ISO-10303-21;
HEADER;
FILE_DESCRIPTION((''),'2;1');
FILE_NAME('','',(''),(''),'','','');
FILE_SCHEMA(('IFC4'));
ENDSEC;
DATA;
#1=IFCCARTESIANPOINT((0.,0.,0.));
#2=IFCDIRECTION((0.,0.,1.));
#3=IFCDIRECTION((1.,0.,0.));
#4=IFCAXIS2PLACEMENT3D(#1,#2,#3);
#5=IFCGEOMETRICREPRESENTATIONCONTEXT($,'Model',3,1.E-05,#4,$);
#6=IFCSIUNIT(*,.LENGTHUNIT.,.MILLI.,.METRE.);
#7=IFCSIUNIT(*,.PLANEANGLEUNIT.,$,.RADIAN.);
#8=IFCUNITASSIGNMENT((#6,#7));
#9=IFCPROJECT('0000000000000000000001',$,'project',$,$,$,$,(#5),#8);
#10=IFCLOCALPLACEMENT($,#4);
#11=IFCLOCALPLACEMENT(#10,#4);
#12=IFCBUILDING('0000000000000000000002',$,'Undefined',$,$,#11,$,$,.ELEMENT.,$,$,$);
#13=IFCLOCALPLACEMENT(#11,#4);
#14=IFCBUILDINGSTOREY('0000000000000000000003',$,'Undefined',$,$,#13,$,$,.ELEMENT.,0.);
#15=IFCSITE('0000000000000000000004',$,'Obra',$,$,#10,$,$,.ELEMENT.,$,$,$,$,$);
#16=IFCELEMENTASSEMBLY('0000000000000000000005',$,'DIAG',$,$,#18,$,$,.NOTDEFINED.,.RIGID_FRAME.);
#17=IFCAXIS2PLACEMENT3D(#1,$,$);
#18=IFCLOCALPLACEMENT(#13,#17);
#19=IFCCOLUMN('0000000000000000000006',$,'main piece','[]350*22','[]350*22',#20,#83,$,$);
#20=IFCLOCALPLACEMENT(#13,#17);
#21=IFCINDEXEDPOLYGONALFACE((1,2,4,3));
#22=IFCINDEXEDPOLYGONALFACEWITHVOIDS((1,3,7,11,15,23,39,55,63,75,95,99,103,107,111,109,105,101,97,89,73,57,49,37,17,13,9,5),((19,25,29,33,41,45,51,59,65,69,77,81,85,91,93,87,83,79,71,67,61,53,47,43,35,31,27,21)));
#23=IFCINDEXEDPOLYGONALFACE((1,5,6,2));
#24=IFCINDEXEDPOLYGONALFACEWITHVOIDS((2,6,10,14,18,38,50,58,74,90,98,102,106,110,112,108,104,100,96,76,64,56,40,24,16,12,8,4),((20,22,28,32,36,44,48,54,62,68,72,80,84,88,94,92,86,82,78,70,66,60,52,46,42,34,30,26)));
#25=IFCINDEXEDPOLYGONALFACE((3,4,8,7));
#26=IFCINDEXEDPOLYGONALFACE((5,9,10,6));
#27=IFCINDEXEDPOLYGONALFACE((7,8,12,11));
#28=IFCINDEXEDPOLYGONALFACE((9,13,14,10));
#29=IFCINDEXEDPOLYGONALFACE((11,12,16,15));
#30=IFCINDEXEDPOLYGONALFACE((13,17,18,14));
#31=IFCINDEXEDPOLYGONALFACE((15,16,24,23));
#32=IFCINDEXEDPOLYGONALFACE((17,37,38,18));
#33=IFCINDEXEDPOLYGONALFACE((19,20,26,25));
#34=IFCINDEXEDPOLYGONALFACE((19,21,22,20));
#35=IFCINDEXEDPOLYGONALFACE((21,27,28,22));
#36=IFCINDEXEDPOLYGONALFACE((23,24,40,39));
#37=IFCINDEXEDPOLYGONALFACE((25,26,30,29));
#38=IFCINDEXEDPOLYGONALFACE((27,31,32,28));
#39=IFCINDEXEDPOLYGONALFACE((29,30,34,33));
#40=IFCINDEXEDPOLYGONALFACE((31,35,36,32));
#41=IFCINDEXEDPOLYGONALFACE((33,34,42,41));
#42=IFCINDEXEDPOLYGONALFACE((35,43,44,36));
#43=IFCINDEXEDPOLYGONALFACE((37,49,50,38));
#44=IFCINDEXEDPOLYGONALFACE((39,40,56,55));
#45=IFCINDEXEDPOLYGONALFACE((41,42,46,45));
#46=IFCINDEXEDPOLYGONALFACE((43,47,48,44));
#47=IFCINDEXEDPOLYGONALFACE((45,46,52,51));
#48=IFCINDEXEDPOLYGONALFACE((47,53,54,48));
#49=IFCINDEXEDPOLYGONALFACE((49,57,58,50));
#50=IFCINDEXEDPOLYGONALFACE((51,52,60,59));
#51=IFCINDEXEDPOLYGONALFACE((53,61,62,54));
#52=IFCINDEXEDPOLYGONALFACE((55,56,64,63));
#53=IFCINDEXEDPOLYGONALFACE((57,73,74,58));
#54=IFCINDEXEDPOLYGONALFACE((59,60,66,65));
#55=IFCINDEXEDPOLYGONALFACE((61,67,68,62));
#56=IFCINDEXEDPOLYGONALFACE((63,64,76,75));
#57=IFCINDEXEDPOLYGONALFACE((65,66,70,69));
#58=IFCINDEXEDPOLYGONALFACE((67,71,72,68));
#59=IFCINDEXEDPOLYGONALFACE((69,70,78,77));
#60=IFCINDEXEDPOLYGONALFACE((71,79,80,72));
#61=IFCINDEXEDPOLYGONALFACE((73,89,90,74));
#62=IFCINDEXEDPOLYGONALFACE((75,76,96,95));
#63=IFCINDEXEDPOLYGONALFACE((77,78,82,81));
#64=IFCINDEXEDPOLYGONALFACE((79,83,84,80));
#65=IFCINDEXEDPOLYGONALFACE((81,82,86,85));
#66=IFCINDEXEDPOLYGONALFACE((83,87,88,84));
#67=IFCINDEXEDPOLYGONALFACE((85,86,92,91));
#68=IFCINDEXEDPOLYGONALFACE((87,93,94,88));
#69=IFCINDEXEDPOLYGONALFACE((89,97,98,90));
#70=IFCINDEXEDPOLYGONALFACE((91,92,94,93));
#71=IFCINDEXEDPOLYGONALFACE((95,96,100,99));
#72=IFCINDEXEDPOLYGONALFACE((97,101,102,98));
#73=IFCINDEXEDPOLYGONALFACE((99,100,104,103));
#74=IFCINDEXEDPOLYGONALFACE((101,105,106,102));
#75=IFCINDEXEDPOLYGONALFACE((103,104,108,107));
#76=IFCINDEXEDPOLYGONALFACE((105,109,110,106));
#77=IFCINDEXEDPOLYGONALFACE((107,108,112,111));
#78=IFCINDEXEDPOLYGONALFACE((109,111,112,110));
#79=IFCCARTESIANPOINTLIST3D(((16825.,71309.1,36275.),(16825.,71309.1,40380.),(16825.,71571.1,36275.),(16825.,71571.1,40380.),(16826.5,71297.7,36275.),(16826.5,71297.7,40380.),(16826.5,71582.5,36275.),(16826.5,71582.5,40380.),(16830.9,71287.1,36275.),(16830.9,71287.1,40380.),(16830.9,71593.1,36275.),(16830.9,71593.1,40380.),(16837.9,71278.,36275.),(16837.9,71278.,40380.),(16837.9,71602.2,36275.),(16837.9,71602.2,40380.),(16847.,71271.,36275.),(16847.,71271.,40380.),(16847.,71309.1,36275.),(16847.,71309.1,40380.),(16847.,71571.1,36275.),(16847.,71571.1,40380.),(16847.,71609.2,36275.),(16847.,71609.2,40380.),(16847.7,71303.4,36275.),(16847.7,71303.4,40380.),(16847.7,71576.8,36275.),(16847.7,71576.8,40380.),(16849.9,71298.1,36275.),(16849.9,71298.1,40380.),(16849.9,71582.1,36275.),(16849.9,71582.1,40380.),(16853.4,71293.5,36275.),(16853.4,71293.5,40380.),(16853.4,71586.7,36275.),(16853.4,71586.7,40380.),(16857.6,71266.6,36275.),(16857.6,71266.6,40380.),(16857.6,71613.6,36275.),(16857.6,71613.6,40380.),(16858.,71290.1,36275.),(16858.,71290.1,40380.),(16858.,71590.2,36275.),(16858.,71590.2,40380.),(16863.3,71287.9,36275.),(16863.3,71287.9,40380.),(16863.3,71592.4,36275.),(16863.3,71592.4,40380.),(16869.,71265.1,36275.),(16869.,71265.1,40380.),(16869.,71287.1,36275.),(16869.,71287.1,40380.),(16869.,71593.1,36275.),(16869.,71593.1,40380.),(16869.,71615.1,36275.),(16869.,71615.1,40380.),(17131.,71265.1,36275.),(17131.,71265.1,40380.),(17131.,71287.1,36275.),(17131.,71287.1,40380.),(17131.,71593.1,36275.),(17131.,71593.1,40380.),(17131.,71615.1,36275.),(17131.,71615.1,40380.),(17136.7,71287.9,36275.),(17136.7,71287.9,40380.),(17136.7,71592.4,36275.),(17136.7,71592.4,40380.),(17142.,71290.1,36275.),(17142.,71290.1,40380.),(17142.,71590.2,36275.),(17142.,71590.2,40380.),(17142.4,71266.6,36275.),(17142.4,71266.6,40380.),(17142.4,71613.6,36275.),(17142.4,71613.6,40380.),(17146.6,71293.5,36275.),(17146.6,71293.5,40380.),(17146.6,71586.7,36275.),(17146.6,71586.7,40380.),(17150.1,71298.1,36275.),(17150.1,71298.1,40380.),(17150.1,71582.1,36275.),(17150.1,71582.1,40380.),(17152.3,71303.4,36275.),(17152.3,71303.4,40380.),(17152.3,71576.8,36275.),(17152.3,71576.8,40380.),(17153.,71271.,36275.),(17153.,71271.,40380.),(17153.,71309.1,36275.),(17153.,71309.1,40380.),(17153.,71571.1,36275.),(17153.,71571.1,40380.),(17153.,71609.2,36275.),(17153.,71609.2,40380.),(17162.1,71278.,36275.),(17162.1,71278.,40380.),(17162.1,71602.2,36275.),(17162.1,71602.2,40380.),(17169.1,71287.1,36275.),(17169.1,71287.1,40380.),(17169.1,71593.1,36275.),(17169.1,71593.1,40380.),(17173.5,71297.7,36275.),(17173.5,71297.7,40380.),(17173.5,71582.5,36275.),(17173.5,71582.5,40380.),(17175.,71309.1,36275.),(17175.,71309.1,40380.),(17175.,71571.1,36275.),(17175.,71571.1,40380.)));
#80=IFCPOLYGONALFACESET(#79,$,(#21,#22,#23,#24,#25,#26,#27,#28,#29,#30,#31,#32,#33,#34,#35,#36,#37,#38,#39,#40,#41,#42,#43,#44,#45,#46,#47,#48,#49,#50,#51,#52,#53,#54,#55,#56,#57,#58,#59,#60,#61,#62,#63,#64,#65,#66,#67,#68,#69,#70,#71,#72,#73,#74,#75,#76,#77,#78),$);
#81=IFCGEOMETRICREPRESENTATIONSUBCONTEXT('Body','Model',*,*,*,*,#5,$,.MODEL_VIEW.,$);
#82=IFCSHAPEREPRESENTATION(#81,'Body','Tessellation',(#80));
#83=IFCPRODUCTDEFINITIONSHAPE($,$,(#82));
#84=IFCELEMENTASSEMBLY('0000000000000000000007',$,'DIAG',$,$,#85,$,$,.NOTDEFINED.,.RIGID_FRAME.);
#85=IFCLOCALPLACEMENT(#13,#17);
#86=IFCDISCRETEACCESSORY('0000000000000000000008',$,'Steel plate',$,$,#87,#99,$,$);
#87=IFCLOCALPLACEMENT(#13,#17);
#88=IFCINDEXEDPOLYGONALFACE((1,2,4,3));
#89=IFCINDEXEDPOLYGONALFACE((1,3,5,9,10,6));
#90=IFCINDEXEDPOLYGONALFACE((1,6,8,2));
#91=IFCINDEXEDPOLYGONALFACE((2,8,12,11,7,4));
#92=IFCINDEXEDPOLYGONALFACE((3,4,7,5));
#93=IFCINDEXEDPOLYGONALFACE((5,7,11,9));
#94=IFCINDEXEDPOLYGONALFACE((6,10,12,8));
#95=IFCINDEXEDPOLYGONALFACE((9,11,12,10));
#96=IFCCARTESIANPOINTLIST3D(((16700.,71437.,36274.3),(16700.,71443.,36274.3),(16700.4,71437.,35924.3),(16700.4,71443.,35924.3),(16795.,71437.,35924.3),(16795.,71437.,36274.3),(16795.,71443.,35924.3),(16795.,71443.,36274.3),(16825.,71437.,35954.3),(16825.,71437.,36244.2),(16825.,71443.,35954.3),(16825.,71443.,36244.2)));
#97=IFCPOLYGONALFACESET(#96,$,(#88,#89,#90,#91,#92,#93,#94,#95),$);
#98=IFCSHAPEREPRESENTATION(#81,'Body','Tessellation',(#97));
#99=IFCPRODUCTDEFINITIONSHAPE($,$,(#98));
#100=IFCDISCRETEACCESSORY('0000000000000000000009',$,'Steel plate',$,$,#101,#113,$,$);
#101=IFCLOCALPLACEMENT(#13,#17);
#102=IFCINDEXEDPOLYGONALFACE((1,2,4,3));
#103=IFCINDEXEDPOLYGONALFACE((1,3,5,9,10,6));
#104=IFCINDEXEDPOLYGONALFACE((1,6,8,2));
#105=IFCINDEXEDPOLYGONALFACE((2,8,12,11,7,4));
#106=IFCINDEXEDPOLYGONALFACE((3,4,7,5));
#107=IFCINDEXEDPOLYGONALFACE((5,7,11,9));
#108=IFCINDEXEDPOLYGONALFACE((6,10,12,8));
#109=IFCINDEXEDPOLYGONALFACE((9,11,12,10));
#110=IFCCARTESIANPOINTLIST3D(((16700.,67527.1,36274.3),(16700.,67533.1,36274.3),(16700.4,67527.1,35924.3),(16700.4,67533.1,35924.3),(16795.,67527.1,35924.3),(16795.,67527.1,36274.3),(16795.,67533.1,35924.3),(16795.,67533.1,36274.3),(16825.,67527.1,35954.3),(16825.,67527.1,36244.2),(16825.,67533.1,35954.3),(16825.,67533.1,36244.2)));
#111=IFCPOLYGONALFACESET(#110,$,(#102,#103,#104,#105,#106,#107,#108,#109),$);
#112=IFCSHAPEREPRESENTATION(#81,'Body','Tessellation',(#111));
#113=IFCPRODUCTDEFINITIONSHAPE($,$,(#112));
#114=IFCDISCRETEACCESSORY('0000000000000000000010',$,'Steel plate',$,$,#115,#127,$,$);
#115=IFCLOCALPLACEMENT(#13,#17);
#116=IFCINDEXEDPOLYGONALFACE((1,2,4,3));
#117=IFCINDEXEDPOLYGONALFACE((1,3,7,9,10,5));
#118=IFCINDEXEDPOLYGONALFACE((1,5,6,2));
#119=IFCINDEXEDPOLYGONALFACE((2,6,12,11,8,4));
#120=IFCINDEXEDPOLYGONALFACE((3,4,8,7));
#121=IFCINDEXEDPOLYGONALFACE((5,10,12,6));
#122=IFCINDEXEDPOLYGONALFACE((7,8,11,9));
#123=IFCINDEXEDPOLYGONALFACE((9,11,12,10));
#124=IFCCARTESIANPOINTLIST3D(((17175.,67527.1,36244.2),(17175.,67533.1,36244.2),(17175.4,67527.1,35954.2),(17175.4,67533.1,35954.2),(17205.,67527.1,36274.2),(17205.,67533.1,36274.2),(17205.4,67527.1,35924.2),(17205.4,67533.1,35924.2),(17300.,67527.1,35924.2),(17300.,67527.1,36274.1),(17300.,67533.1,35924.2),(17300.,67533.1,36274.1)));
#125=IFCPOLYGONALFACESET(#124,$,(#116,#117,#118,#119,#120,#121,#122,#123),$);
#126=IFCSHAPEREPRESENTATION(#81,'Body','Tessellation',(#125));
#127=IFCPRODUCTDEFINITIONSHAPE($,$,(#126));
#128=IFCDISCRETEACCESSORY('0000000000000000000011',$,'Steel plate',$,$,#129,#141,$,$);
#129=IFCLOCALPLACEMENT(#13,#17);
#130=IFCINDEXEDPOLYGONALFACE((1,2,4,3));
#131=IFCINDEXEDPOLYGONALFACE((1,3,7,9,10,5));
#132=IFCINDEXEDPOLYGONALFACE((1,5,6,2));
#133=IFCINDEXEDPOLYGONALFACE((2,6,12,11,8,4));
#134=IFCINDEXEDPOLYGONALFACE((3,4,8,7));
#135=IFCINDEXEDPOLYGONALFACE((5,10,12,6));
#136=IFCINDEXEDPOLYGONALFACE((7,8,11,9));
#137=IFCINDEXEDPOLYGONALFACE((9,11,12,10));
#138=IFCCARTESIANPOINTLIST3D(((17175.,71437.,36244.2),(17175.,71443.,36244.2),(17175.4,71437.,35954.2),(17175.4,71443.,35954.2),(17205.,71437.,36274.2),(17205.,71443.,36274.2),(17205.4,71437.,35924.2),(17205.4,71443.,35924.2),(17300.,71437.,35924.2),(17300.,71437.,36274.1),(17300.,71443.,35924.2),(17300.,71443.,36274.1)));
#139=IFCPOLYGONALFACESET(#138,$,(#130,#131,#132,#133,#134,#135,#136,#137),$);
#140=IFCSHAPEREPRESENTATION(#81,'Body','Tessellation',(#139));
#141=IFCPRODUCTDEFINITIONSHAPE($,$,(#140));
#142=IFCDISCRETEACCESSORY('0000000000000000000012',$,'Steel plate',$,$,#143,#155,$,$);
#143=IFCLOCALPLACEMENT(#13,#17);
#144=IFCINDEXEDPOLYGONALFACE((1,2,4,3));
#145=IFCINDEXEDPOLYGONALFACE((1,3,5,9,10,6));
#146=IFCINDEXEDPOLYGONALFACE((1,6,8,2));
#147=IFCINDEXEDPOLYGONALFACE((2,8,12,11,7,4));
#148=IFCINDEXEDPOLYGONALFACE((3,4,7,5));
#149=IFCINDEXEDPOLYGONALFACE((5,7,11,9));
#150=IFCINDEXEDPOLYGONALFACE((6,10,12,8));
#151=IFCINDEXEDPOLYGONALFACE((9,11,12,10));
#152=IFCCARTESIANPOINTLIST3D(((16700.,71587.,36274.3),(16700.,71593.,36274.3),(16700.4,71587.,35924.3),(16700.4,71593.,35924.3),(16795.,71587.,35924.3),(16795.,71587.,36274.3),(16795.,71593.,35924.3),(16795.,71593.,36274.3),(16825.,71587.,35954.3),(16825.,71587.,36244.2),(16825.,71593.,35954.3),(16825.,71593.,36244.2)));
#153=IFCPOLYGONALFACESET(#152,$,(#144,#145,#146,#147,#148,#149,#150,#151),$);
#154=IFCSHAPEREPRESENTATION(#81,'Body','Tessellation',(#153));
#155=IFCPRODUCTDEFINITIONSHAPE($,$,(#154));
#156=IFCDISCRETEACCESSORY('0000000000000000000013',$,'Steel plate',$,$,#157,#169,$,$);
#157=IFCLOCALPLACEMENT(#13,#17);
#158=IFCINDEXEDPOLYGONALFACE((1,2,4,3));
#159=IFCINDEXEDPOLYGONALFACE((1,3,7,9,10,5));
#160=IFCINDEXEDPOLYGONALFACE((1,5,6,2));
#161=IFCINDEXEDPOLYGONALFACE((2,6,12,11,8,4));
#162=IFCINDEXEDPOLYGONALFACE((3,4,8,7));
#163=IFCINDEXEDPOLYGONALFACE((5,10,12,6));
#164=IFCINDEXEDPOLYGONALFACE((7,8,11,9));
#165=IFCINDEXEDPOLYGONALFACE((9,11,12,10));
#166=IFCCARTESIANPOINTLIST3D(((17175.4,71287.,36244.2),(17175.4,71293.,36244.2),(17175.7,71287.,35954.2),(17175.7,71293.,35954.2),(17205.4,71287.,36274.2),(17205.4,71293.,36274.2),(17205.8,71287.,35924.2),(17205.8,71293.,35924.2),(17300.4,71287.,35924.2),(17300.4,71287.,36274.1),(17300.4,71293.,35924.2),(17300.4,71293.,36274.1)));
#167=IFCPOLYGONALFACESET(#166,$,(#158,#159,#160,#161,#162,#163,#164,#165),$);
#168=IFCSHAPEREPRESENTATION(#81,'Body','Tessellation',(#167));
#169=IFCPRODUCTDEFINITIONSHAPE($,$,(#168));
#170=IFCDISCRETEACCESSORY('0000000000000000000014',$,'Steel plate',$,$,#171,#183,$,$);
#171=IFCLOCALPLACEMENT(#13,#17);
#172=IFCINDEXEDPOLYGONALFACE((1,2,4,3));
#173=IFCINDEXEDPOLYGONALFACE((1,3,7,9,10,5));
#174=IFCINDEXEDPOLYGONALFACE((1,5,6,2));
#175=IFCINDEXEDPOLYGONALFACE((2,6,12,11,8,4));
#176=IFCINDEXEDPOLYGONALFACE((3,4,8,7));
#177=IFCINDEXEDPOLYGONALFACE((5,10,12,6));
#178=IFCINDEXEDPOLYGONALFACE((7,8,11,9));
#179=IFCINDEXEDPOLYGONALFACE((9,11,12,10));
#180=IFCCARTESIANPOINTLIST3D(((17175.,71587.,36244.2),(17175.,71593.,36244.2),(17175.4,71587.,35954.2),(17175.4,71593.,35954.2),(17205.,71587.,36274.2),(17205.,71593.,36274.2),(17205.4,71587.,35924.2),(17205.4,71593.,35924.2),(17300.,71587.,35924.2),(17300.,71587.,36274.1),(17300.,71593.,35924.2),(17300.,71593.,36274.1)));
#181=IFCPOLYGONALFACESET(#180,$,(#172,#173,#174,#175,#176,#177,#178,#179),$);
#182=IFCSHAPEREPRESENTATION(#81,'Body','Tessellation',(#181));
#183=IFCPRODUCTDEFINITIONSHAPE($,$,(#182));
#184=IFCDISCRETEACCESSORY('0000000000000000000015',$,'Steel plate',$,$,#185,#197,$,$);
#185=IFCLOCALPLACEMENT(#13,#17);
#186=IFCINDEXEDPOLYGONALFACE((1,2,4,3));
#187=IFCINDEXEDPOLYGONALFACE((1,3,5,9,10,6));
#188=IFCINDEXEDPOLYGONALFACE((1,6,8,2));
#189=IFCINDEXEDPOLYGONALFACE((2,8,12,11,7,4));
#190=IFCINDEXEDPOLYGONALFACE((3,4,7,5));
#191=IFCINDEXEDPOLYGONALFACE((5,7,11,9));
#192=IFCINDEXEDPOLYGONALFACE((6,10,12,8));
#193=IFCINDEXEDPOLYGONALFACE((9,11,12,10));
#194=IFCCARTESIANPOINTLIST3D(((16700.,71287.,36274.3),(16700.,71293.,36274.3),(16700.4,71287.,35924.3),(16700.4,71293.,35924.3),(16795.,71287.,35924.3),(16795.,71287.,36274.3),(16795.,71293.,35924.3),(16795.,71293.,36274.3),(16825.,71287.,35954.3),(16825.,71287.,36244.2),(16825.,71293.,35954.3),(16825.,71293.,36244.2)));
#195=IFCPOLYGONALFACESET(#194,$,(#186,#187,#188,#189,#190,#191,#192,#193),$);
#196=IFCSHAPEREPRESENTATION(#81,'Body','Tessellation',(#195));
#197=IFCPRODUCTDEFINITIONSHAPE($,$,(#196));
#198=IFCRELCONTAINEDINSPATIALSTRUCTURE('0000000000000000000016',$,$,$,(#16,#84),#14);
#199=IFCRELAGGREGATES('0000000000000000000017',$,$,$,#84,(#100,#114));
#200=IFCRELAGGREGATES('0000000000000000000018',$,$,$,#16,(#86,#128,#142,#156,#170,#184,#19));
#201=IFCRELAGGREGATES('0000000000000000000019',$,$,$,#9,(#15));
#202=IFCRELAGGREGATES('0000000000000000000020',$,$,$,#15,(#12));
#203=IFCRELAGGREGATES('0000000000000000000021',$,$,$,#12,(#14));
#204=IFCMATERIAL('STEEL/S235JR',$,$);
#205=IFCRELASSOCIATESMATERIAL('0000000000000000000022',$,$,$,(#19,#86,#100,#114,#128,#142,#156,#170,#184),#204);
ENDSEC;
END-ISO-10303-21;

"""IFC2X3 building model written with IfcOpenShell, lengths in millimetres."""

from ifc_helpers import new_model, si_unit, frame, origin_with_axes, origin_2d_with_axis, place, context, subcontext, project, spatial, polyline, hollow_rectangle, outline, extrude, material, element, aggregate, save


model = new_model("IFC2X3")

# Units and contexts
model_context = context("Model", 3, precision=1e-05, world=origin_with_axes())
body_context = subcontext(model_context, "Body", "Model", "MODEL_VIEW")
ifc_project = project(units=[si_unit("LENGTHUNIT", "METRE", prefix="MILLI"), si_unit("PLANEANGLEUNIT", "RADIAN")], contexts=[model_context])

# Site, building, storey
site_placement = place(None, origin_with_axes())
site = spatial("IfcSite", under=ifc_project, at=site_placement, Name="Obra", CompositionType="ELEMENT")
building_placement = place(site_placement, origin_with_axes())
building = spatial("IfcBuilding", under=site, at=building_placement, Name="Undefined", CompositionType="ELEMENT")
storey_placement = place(building_placement, origin_with_axes())
storey = spatial("IfcBuildingStorey", under=building, at=storey_placement, Name="Undefined", CompositionType="ELEMENT", Elevation=0.0)

# Element assembly, column
assembly_1_placement = place(storey_placement, origin_with_axes())
assembly_1 = element("IfcElementAssembly", 1, at=assembly_1_placement, inside=storey, Name="DIAG", AssemblyPlace="NOTDEFINED", PredefinedType="RIGID_FRAME")
ifc_material_1 = material(Name="STEEL/S235JR")
column_placement = place(assembly_1_placement, frame((17000.0, 71440.1, 36275.0), z_axis=(0.0, 0.0, 1.0), x_axis=(-1.0, 0.0, 0.0)))
column = element("IfcColumn", 2, at=column_placement, material=ifc_material_1, Name="main piece", Description="[]350*22", ObjectType="[]350*22", context=body_context, shape_type="SweptSolid", body=[
    extrude(hollow_rectangle(XDim=350.0, YDim=350.0, WallThickness=22.0, InnerFilletRadius=22.0, OuterFilletRadius=44.0, at=origin_2d_with_axis()), frame((0.0, 0.0, 4105.0), z_axis=(0.0, 0.0, -1.0), x_axis=(0.0, 1.0, 0.0)), (0.0, 0.0, 1.0), 4105.0),
])

# Element assembly
assembly_2_placement = place(storey_placement, origin_with_axes())
assembly_2 = element("IfcElementAssembly", 3, at=assembly_2_placement, inside=storey, Name="DIAG", AssemblyPlace="NOTDEFINED", PredefinedType="RIGID_FRAME")

# Discrete accessory
discrete_accessory_1_placement = place(assembly_1_placement, frame((16825.0, 71440.0, 35924.3), z_axis=(0.0, 1.0, 0.0), x_axis=(-1.0, 0.0, 0.0)))
discrete_accessory_1 = element("IfcDiscreteAccessory", 4, at=discrete_accessory_1_placement, material=ifc_material_1, Name="Steel plate", context=body_context, shape_type="SweptSolid", body=[
    extrude(outline(polyline([(0.0, 30.0), (30.0, 0.0), (124.6, 0.0), (125.0, 350.0), (30.0, 349.9), (0.0, 319.9), (0.0, 30.0)])), frame((0.0, 0.0, -3.0), z_axis=(0.0, 0.0, 1.0), x_axis=(1.0, 0.0, 0.0)), (0.0, 0.0, 1.0), 6.0),
])

# Discrete accessories
discrete_accessory_2_placement = place(assembly_2_placement, frame((16825.0, 67530.1, 35924.3), z_axis=(0.0, 1.0, 0.0), x_axis=(-1.0, 0.0, 0.0)))
discrete_accessory_2 = element("IfcDiscreteAccessory", 5, at=discrete_accessory_2_placement, material=ifc_material_1, Name="Steel plate", context=body_context, shape_type="SweptSolid", body=[
    extrude(outline(polyline([(0.0, 30.0), (30.0, 0.0), (124.6, 0.0), (125.0, 350.0), (30.0, 349.9), (0.0, 319.9), (0.0, 30.0)])), frame((0.0, 0.0, -3.0), z_axis=(0.0, 0.0, 1.0), x_axis=(1.0, 0.0, 0.0)), (0.0, 0.0, 1.0), 6.0),
])
discrete_accessory_3_placement = place(assembly_2_placement, frame((17300.0, 67530.1, 35924.2), z_axis=(0.0, 1.0, 0.0), x_axis=(-1.0, 0.0, 0.0)))
discrete_accessory_3 = element("IfcDiscreteAccessory", 6, at=discrete_accessory_3_placement, material=ifc_material_1, Name="Steel plate", context=body_context, shape_type="SweptSolid", body=[
    extrude(outline(polyline([(0.0, 0.0), (94.6, 0.0), (124.6, 30.0), (125.0, 320.0), (95.0, 350.0), (0.0, 349.9), (0.0, 0.0)])), frame((0.0, 0.0, -3.0), z_axis=(0.0, 0.0, 1.0), x_axis=(1.0, 0.0, 0.0)), (0.0, 0.0, 1.0), 6.0),
])
discrete_accessory_4_placement = place(assembly_1_placement, frame((17300.0, 71440.0, 35924.2), z_axis=(0.0, 1.0, 0.0), x_axis=(-1.0, 0.0, 0.0)))
discrete_accessory_4 = element("IfcDiscreteAccessory", 7, at=discrete_accessory_4_placement, material=ifc_material_1, Name="Steel plate", context=body_context, shape_type="SweptSolid", body=[
    extrude(outline(polyline([(0.0, 0.0), (94.6, 0.0), (124.6, 30.0), (125.0, 320.0), (95.0, 350.0), (0.0, 349.9), (0.0, 0.0)])), frame((0.0, 0.0, -3.0), z_axis=(0.0, 0.0, 1.0), x_axis=(1.0, 0.0, 0.0)), (0.0, 0.0, 1.0), 6.0),
])
discrete_accessory_5_placement = place(assembly_1_placement, frame((16825.0, 71590.0, 35924.3), z_axis=(0.0, 1.0, 0.0), x_axis=(-1.0, 0.0, 0.0)))
discrete_accessory_5 = element("IfcDiscreteAccessory", 8, at=discrete_accessory_5_placement, material=ifc_material_1, Name="Steel plate", context=body_context, shape_type="SweptSolid", body=[
    extrude(outline(polyline([(0.0, 30.0), (30.0, 0.0), (124.6, 0.0), (125.0, 350.0), (30.0, 349.9), (0.0, 319.9), (0.0, 30.0)])), frame((0.0, 0.0, -3.0), z_axis=(0.0, 0.0, 1.0), x_axis=(1.0, 0.0, 0.0)), (0.0, 0.0, 1.0), 6.0),
])
discrete_accessory_6_placement = place(assembly_1_placement, frame((17300.4, 71290.0, 35924.2), z_axis=(0.0, 1.0, 0.0), x_axis=(-1.0, 0.0, 0.0)))
discrete_accessory_6 = element("IfcDiscreteAccessory", 9, at=discrete_accessory_6_placement, material=ifc_material_1, Name="Steel plate", context=body_context, shape_type="SweptSolid", body=[
    extrude(outline(polyline([(0.0, 0.0), (94.6, 0.0), (124.6, 30.0), (125.0, 320.0), (95.0, 350.0), (0.0, 349.9), (0.0, 0.0)])), frame((0.0, 0.0, -3.0), z_axis=(0.0, 0.0, 1.0), x_axis=(1.0, 0.0, 0.0)), (0.0, 0.0, 1.0), 6.0),
])
discrete_accessory_7_placement = place(assembly_1_placement, frame((17300.0, 71590.0, 35924.2), z_axis=(0.0, 1.0, 0.0), x_axis=(-1.0, 0.0, 0.0)))
discrete_accessory_7 = element("IfcDiscreteAccessory", 10, at=discrete_accessory_7_placement, material=ifc_material_1, Name="Steel plate", context=body_context, shape_type="SweptSolid", body=[
    extrude(outline(polyline([(0.0, 0.0), (94.6, 0.0), (124.6, 30.0), (125.0, 320.0), (95.0, 350.0), (0.0, 349.9), (0.0, 0.0)])), frame((0.0, 0.0, -3.0), z_axis=(0.0, 0.0, 1.0), x_axis=(1.0, 0.0, 0.0)), (0.0, 0.0, 1.0), 6.0),
])
discrete_accessory_8_placement = place(assembly_1_placement, frame((16825.0, 71290.0, 35924.3), z_axis=(0.0, 1.0, 0.0), x_axis=(-1.0, 0.0, 0.0)))
discrete_accessory_8 = element("IfcDiscreteAccessory", 11, at=discrete_accessory_8_placement, material=ifc_material_1, Name="Steel plate", context=body_context, shape_type="SweptSolid", body=[
    extrude(outline(polyline([(0.0, 30.0), (30.0, 0.0), (124.6, 0.0), (125.0, 350.0), (30.0, 349.9), (0.0, 319.9), (0.0, 30.0)])), frame((0.0, 0.0, -3.0), z_axis=(0.0, 0.0, 1.0), x_axis=(1.0, 0.0, 0.0)), (0.0, 0.0, 1.0), 6.0),
])

aggregate(assembly_2, [discrete_accessory_2, discrete_accessory_3])

aggregate(assembly_1, [discrete_accessory_1, discrete_accessory_4, discrete_accessory_5, discrete_accessory_6, discrete_accessory_7, discrete_accessory_8, column])

save(model, "model.ifc")
